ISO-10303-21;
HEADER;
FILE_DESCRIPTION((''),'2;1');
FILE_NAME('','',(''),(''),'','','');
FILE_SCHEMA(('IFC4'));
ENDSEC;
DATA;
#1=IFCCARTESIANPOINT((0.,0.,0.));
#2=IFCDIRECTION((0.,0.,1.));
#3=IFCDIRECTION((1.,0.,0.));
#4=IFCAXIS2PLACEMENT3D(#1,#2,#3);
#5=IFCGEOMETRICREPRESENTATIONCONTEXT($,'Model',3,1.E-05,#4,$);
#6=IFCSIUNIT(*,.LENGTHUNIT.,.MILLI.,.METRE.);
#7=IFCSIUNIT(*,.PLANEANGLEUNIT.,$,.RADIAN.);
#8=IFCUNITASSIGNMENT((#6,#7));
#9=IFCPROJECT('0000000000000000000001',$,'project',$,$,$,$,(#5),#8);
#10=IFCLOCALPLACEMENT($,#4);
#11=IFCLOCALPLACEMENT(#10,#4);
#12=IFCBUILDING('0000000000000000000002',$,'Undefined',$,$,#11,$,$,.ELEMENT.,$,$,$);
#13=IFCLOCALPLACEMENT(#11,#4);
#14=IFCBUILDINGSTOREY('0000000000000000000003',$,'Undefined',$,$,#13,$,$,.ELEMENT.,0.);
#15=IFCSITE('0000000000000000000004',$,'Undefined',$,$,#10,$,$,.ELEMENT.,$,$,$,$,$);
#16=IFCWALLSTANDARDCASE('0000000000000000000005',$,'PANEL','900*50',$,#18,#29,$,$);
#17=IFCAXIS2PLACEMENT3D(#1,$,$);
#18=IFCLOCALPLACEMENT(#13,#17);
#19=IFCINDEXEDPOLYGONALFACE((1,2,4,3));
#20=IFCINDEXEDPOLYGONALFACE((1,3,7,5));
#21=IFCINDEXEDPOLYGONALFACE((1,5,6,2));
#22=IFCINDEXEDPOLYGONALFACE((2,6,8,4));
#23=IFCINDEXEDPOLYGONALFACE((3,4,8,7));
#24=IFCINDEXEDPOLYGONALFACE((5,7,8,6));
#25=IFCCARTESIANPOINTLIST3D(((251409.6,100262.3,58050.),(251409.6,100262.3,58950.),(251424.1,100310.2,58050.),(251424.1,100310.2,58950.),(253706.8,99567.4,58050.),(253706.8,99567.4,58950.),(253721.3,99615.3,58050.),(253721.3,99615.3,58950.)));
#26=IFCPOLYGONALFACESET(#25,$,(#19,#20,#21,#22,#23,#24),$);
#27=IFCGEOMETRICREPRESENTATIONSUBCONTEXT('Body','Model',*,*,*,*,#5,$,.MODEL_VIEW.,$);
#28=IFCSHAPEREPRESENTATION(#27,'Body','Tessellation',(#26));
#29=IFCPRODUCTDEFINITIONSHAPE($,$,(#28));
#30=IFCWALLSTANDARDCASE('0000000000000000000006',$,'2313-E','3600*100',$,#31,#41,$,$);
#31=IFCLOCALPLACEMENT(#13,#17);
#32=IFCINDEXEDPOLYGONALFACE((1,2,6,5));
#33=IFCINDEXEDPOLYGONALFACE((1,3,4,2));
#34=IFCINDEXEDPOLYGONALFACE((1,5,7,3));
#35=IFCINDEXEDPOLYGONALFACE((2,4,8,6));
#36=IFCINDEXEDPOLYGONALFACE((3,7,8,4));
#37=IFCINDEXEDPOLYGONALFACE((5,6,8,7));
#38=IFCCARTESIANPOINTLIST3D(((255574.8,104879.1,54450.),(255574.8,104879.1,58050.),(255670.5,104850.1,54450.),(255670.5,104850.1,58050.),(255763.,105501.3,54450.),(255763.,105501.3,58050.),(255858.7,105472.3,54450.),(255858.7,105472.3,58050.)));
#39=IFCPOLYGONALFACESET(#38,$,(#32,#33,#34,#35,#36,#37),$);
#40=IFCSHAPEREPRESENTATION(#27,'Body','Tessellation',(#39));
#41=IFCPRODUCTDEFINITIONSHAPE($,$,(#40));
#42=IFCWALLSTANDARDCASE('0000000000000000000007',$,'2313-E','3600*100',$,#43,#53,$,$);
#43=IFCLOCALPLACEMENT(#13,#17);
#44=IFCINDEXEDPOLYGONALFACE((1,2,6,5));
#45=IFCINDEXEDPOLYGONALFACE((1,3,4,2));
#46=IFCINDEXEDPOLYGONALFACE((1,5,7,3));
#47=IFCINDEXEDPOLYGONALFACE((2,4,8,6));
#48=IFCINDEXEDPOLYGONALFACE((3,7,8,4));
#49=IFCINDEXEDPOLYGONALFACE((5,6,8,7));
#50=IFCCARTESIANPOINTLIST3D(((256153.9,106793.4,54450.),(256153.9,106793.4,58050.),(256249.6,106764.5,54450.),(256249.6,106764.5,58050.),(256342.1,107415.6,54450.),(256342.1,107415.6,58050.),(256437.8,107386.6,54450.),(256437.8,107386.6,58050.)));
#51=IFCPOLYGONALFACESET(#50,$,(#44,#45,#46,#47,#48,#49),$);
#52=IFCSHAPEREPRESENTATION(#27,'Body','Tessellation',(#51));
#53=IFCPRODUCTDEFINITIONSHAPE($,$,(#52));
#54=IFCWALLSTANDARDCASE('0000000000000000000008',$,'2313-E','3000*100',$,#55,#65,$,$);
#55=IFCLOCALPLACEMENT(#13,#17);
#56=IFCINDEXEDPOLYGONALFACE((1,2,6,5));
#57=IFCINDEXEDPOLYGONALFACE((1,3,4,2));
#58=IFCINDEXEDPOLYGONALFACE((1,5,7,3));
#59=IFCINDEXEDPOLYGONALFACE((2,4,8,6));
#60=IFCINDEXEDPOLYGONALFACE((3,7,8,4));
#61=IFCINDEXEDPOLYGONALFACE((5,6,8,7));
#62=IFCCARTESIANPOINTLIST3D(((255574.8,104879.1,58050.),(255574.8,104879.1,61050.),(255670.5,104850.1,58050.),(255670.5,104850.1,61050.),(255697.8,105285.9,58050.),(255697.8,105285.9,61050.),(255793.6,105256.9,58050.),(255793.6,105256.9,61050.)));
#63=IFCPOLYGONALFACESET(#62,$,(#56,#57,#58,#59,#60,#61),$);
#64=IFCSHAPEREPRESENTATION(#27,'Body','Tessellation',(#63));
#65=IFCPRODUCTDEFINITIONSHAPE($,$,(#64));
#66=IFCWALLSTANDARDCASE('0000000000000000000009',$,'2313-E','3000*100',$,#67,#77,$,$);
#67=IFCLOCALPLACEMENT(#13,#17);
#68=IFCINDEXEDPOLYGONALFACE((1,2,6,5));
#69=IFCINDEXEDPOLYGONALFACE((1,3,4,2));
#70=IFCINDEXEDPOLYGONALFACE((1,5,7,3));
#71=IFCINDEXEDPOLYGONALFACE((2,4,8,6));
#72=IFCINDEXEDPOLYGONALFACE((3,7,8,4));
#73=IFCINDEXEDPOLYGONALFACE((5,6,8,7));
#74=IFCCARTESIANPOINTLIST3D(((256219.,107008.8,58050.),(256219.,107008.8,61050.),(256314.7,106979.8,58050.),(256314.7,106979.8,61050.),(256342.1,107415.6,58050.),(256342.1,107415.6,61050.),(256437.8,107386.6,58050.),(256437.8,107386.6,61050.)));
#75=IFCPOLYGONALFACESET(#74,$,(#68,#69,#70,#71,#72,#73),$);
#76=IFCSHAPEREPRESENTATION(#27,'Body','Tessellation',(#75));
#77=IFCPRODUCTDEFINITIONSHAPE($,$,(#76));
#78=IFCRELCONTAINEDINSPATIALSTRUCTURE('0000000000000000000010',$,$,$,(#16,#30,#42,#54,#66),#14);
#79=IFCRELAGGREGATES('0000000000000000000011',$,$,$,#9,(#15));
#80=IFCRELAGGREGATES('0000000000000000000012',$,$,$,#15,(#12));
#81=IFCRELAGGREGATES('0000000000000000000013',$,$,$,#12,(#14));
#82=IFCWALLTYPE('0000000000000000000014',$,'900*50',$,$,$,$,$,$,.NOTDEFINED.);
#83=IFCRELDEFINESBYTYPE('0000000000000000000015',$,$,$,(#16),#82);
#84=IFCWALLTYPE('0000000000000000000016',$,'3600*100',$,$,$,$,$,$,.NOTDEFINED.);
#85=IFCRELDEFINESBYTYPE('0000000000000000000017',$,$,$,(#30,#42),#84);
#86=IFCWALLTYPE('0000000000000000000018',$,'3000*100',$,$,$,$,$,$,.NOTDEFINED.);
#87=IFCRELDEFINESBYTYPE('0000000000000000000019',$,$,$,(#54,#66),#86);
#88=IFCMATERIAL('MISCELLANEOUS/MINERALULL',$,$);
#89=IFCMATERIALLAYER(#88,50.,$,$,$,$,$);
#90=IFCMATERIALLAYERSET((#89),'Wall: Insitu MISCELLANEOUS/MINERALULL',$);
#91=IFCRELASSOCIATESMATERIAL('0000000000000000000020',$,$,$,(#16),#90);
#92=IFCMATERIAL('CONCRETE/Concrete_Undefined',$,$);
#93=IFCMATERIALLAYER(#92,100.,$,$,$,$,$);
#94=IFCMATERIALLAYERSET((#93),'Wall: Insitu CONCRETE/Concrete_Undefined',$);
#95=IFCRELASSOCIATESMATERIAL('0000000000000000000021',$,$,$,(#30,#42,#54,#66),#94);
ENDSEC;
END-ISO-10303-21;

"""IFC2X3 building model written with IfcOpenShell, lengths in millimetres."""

from ifc_helpers import new_model, si_unit, frame, frame_2d, origin_with_axes, place, context, subcontext, project, spatial, rectangle, extrude, material, layer, layer_set, layer_usage, type_object, element, save


model = new_model("IFC2X3")

# Units and contexts
model_context = context("Model", 3, precision=1e-05, world=origin_with_axes())
body_context = subcontext(model_context, "Body", "Model", "MODEL_VIEW")
ifc_project = project(units=[si_unit("LENGTHUNIT", "METRE", prefix="MILLI"), si_unit("PLANEANGLEUNIT", "RADIAN")], contexts=[model_context])

# Site, building, storey
site_placement = place(None, origin_with_axes())
site = spatial("IfcSite", under=ifc_project, at=site_placement, Name="Undefined", CompositionType="ELEMENT")
building_placement = place(site_placement, origin_with_axes())
building = spatial("IfcBuilding", under=site, at=building_placement, Name="Undefined", CompositionType="ELEMENT")
storey_placement = place(building_placement, origin_with_axes())
storey = spatial("IfcBuildingStorey", under=building, at=storey_placement, Name="Undefined", CompositionType="ELEMENT", Elevation=0.0)

# Shared definitions
ifc_material_1 = material(Name="CONCRETE/Concrete_Undefined")

# Walls
ifc_material_2 = material(Name="MISCELLANEOUS/MINERALULL")
ifc_layer_1 = layer(ifc_material_2, 50.0)
ifc_layer_set_1 = layer_set([ifc_layer_1], Name="Wall: Insitu MISCELLANEOUS/MINERALULL")
ifc_layer_usage_1 = layer_usage(ifc_layer_set_1, "AXIS2", "POSITIVE", -25.0)
wall_type_1 = type_object("IfcWallType", Name="900*50", PredefinedType="NOTDEFINED")
wall_1_placement = place(storey_placement, frame((251416.9, 100286.2, 58050.0), z_axis=(0.0, 0.0, 1.0), x_axis=(0.957166, -0.289539, 0.0)))
element("IfcWallStandardCase", 1, at=wall_1_placement, inside=storey, type_object=wall_type_1, material=ifc_layer_usage_1, Name="PANEL", Description="900*50", context=body_context, shape_type="SweptSolid", body=[
    extrude(rectangle(XDim=2400.0, YDim=50.0, at=frame_2d((0.0, 1200.0), x_axis=(0.0, -1.0))), frame((0.0, 0.0, 0.0), z_axis=(0.0, 0.0, 1.0), x_axis=(0.0, -1.0, 0.0)), (0.0, 0.0, 1.0), 900.0),
])
ifc_layer_2 = layer(ifc_material_1, 100.0)
ifc_layer_set_2 = layer_set([ifc_layer_2], Name="Wall: Insitu CONCRETE/Concrete_Undefined")
ifc_layer_usage_2 = layer_usage(ifc_layer_set_2, "AXIS2", "POSITIVE", -50.0)
wall_type_2 = type_object("IfcWallType", Name="3600*100", PredefinedType="NOTDEFINED")
wall_2_placement = place(storey_placement, frame((255810.8, 105486.8, 54450.0), z_axis=(0.0, 0.0, 1.0), x_axis=(-0.289535, -0.957167, 0.0)))
element("IfcWallStandardCase", 2, at=wall_2_placement, inside=storey, type_object=wall_type_2, material=ifc_layer_usage_2, Name="2313-E", Description="3600*100", context=body_context, shape_type="SweptSolid", body=[
    extrude(rectangle(XDim=650.0, YDim=100.0, at=frame_2d((0.0, 325.0), x_axis=(0.0, -1.0))), frame((0.0, 0.0, 0.0), z_axis=(0.0, 0.0, 1.0), x_axis=(0.0, -1.0, 0.0)), (0.0, 0.0, 1.0), 3600.0),
])
ifc_layer_usage_3 = layer_usage(ifc_layer_set_2, "AXIS2", "POSITIVE", -50.0)
wall_3_placement = place(storey_placement, frame((256389.9, 107401.1, 54450.0), z_axis=(0.0, 0.0, 1.0), x_axis=(-0.289535, -0.957167, 0.0)))
element("IfcWallStandardCase", 3, at=wall_3_placement, inside=storey, type_object=wall_type_2, material=ifc_layer_usage_3, Name="2313-E", Description="3600*100", context=body_context, shape_type="SweptSolid", body=[
    extrude(rectangle(XDim=650.0, YDim=100.0, at=frame_2d((0.0, 325.0), x_axis=(0.0, -1.0))), frame((0.0, 0.0, 0.0), z_axis=(0.0, 0.0, 1.0), x_axis=(0.0, -1.0, 0.0)), (0.0, 0.0, 1.0), 3600.0),
])
ifc_layer_usage_4 = layer_usage(ifc_layer_set_2, "AXIS2", "POSITIVE", -50.0)
wall_type_3 = type_object("IfcWallType", Name="3000*100", PredefinedType="NOTDEFINED")
wall_4_placement = place(storey_placement, frame((255745.7, 105271.4, 58050.0), z_axis=(0.0, 0.0, 1.0), x_axis=(-0.289534, -0.957168, 0.0)))
element("IfcWallStandardCase", 4, at=wall_4_placement, inside=storey, type_object=wall_type_3, material=ifc_layer_usage_4, Name="2313-E", Description="3000*100", context=body_context, shape_type="SweptSolid", body=[
    extrude(rectangle(XDim=425.0, YDim=100.0, at=frame_2d((0.0, 212.5), x_axis=(0.0, -1.0))), frame((0.0, 0.0, 0.0), z_axis=(0.0, 0.0, 1.0), x_axis=(0.0, -1.0, 0.0)), (0.0, 0.0, 1.0), 3000.0),
])
ifc_layer_usage_5 = layer_usage(ifc_layer_set_2, "AXIS2", "POSITIVE", -50.0)
wall_5_placement = place(storey_placement, frame((256389.9, 107401.1, 58050.0), z_axis=(0.0, 0.0, 1.0), x_axis=(-0.289534, -0.957168, 0.0)))
element("IfcWallStandardCase", 5, at=wall_5_placement, inside=storey, type_object=wall_type_3, material=ifc_layer_usage_5, Name="2313-E", Description="3000*100", context=body_context, shape_type="SweptSolid", body=[
    extrude(rectangle(XDim=425.0, YDim=100.0, at=frame_2d((0.0, 212.5), x_axis=(0.0, -1.0))), frame((0.0, 0.0, 0.0), z_axis=(0.0, 0.0, 1.0), x_axis=(0.0, -1.0, 0.0)), (0.0, 0.0, 1.0), 3000.0),
])

save(model, "model.ifc")
